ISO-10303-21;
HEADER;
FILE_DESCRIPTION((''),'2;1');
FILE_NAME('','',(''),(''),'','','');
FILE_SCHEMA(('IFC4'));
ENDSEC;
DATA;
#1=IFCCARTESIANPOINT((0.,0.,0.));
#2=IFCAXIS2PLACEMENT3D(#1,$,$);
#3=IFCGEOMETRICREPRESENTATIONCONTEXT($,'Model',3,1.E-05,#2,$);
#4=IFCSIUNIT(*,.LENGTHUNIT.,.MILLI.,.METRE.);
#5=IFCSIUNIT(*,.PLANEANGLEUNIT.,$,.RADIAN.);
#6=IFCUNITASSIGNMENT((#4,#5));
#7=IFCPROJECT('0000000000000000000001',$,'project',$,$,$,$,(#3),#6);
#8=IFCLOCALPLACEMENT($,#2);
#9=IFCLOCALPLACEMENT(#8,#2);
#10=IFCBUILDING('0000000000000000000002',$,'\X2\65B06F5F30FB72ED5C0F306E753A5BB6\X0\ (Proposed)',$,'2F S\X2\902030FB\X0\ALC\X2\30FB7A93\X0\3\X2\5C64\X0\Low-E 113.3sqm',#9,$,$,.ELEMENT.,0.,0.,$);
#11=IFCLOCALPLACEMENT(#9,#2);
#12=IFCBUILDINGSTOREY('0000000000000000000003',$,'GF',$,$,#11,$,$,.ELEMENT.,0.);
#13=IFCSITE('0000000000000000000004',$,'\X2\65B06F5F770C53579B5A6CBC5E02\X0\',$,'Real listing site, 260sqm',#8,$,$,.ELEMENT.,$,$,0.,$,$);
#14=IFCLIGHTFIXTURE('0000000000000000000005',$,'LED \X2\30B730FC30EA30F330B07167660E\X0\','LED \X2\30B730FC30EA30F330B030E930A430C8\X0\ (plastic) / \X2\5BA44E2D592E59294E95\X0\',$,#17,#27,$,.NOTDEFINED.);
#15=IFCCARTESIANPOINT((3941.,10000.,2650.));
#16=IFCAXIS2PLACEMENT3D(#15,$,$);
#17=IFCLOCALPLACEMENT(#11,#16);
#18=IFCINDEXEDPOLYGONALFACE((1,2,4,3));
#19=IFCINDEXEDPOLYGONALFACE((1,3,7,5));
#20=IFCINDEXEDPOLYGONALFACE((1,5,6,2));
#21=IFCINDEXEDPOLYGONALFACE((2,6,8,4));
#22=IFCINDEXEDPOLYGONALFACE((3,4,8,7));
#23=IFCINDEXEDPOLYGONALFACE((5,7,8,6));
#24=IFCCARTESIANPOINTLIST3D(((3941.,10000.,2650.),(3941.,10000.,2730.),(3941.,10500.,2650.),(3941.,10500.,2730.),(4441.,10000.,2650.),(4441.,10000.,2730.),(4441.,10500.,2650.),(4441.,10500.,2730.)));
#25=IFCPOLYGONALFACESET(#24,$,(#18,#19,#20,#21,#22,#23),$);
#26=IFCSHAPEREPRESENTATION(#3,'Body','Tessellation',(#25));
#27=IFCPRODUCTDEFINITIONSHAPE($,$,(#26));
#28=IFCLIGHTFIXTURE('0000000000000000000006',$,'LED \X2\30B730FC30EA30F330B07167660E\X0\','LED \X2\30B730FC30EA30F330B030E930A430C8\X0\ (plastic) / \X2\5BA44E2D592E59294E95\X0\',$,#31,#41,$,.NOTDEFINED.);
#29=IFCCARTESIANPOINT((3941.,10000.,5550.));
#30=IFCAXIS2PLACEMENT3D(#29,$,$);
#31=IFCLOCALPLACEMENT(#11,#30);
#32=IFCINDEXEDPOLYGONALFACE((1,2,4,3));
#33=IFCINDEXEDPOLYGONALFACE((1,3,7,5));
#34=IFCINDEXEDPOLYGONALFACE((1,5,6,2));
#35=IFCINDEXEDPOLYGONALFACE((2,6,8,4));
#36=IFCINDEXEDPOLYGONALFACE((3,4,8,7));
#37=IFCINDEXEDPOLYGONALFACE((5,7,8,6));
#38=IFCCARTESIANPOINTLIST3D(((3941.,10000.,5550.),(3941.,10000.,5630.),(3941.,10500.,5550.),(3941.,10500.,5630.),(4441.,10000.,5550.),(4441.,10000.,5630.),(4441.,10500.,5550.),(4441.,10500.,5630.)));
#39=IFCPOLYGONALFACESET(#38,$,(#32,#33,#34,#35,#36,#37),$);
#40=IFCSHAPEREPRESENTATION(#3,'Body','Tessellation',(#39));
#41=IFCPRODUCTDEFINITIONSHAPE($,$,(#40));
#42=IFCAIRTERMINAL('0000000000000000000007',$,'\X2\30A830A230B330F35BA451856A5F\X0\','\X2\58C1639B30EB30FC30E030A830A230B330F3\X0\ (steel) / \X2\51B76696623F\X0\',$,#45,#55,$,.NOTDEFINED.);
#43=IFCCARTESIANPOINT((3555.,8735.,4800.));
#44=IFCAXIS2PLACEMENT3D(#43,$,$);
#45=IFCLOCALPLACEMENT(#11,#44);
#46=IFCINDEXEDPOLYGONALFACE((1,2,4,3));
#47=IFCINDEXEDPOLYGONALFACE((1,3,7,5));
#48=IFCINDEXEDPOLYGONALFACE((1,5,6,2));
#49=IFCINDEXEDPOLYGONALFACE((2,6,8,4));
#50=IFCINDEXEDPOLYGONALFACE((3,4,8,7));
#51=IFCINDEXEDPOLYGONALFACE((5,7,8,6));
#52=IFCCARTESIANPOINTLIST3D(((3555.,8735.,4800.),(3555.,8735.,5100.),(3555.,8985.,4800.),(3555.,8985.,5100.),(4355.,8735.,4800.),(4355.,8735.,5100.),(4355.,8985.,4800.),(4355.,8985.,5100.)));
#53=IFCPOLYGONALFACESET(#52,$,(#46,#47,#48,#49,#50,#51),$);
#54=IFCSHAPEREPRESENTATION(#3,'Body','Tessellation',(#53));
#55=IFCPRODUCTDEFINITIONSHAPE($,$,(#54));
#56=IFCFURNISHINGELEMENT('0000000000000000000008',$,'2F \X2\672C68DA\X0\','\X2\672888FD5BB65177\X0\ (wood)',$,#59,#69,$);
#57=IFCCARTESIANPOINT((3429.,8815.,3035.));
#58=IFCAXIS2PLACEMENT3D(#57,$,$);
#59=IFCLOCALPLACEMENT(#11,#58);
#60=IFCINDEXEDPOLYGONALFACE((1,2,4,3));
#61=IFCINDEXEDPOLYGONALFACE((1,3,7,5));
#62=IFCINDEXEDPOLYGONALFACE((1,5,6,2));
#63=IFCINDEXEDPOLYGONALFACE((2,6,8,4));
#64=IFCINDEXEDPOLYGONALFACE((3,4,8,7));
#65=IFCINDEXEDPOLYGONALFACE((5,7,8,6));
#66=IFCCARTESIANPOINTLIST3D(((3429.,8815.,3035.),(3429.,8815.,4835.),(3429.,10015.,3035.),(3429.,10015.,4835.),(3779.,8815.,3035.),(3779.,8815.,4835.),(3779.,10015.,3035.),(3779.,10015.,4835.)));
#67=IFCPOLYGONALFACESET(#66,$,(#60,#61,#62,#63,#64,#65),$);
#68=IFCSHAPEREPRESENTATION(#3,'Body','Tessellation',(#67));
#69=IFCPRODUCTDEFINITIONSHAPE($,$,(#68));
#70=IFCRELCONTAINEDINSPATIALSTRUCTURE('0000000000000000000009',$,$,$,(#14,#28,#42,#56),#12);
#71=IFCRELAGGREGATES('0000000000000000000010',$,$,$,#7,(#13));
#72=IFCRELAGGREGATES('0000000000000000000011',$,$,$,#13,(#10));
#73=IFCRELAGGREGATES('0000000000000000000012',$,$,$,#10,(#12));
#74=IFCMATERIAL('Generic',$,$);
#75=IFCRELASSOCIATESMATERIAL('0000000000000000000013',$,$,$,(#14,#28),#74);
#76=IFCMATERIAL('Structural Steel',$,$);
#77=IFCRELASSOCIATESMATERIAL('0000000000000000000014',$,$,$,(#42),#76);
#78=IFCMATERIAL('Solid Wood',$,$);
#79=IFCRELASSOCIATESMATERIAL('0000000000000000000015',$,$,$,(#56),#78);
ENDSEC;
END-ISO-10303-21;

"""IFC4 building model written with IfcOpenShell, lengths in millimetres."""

from ifc_helpers import new_model, si_unit, frame, frame_2d, origin, place, context, project, spatial, rectangle, extrude, material, element, save


model = new_model("IFC4")

# Units and contexts
model_context = context("Model", 3, precision=1e-05, world=origin())
ifc_project = project(units=[si_unit("LENGTHUNIT", "METRE", prefix="MILLI"), si_unit("PLANEANGLEUNIT", "RADIAN")], contexts=[model_context])

# Site, building, storey
site_placement = place(None, origin())
site = spatial("IfcSite", under=ifc_project, at=site_placement, Name="新潟県南魚沼市", ObjectType="Real listing site, 260sqm", CompositionType="ELEMENT", RefElevation=0.0)
building_placement = place(site_placement, origin())
building = spatial("IfcBuilding", under=site, at=building_placement, Name="新潟・狭小の町家 (Proposed)", ObjectType="2F S造・ALC・窓3層Low-E 113.3sqm", CompositionType="ELEMENT", ElevationOfRefHeight=0.0, ElevationOfTerrain=0.0)
storey_placement = place(building_placement, origin())
storey = spatial("IfcBuildingStorey", under=building, at=storey_placement, Name="GF", CompositionType="ELEMENT", Elevation=0.0)

# Shared definitions
ifc_material_1 = material(Name="Solid Wood")

# Shared definitions
ifc_material_2 = material(Name="Structural Steel")

# Shared definitions
ifc_material_3 = material(Name="Generic")

# Light fixtures
light_fixture_1_placement = place(storey_placement, frame((3941.0, 10000.0, 2650.0)))
element("IfcLightFixture", 1, at=light_fixture_1_placement, inside=storey, material=ifc_material_3, Name="LED シーリング照明", Description="LED シーリングライト (plastic) / 室中央天井", PredefinedType="NOTDEFINED", context=model_context, shape_type="SweptSolid", body=[
    extrude(rectangle(XDim=500.0, YDim=500.0, at=frame_2d((250.0, 250.0))), frame((3941.0, 10000.0, 2650.0)), (0.0, 0.0, 1.0), 80.0),
])
light_fixture_2_placement = place(storey_placement, frame((3941.0, 10000.0, 5550.0)))
element("IfcLightFixture", 2, at=light_fixture_2_placement, inside=storey, material=ifc_material_3, Name="LED シーリング照明", Description="LED シーリングライト (plastic) / 室中央天井", PredefinedType="NOTDEFINED", context=model_context, shape_type="SweptSolid", body=[
    extrude(rectangle(XDim=500.0, YDim=500.0, at=frame_2d((250.0, 250.0))), frame((3941.0, 10000.0, 5550.0)), (0.0, 0.0, 1.0), 80.0),
])

# Air terminal
air_terminal_placement = place(storey_placement, frame((3555.0, 8735.0, 4800.0)))
element("IfcAirTerminal", 3, at=air_terminal_placement, inside=storey, material=ifc_material_2, Name="エアコン室内機", Description="壁掛ルームエアコン (steel) / 冷暖房", PredefinedType="NOTDEFINED", context=model_context, shape_type="SweptSolid", body=[
    extrude(rectangle(XDim=800.0, YDim=250.0, at=frame_2d((400.0, 125.0))), frame((3555.0, 8735.0, 4800.0)), (0.0, 0.0, 1.0), 300.0),
])

# Furnishing element
furnishing_placement = place(storey_placement, frame((3429.0, 8815.0, 3035.0)))
element("IfcFurnishingElement", 4, at=furnishing_placement, inside=storey, material=ifc_material_1, Name="2F 本棚", Description="木製家具 (wood)", context=model_context, shape_type="SweptSolid", body=[
    extrude(rectangle(XDim=350.0, YDim=1200.0, at=frame_2d((175.0, 600.0))), frame((3429.0, 8815.0, 3035.0)), (0.0, 0.0, 1.0), 1800.0),
])

save(model, "model.ifc")
